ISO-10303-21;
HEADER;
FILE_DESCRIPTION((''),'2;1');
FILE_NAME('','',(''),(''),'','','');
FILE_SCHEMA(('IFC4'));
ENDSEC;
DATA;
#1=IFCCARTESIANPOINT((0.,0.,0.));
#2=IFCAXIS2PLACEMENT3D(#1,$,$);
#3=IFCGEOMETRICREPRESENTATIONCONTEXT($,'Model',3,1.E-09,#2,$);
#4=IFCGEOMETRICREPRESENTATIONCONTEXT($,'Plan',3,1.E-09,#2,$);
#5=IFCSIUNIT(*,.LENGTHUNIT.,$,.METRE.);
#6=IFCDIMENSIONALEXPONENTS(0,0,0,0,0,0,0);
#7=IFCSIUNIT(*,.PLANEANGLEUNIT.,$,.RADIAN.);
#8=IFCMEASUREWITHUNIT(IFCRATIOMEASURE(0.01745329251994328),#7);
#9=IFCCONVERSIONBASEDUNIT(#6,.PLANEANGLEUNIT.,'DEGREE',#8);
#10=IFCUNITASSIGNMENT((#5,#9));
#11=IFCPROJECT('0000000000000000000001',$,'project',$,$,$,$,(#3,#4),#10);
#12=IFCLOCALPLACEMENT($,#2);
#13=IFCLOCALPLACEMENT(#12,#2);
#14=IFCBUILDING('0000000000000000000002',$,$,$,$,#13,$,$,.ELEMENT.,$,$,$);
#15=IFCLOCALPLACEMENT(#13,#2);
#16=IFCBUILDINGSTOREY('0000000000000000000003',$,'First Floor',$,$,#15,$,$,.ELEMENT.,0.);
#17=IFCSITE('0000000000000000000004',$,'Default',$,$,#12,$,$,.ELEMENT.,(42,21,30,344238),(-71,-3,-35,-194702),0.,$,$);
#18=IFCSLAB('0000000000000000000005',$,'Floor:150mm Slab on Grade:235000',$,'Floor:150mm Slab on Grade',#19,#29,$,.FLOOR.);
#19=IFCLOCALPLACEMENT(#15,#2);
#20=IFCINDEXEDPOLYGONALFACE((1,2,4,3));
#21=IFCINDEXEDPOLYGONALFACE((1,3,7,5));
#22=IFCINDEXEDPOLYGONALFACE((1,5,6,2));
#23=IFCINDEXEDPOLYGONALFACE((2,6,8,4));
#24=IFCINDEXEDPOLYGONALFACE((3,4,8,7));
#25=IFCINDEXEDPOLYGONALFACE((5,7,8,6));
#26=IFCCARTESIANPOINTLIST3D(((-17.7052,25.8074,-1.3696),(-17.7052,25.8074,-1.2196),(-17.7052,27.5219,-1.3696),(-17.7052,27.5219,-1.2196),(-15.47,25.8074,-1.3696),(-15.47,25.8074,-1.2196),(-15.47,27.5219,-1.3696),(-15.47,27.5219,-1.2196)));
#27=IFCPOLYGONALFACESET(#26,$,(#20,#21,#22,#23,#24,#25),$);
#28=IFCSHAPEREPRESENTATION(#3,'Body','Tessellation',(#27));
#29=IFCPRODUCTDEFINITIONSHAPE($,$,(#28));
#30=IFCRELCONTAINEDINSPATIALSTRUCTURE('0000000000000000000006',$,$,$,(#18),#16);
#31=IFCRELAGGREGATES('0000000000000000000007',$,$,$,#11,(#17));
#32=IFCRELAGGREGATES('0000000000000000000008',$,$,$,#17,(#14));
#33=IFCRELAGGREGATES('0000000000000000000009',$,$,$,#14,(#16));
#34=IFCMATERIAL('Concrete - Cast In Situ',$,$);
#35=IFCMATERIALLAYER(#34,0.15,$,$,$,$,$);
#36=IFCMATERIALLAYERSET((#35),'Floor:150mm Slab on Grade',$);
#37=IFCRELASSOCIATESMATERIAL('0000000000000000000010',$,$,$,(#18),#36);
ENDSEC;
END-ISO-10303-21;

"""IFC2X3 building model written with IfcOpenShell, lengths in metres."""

from ifc_helpers import new_model, entity, si_unit, converted_unit, frame, origin, origin_2d_with_axis, place, context, project, spatial, rectangle, extrude, material, layer, layer_set, layer_usage, element, save


model = new_model("IFC2X3")

# Units and contexts
model_context = context("Model", 3, precision=1e-09, world=origin())
plan_context = context("Plan", 3, precision=1e-09, world=origin())
ifc_project = project(units=[si_unit("LENGTHUNIT", "METRE"), converted_unit("PLANEANGLEUNIT", "DEGREE", entity("IfcRatioMeasure", 0.01745329251994328), si_unit("PLANEANGLEUNIT", "RADIAN"), dimensions=[0, 0, 0, 0, 0, 0, 0])], contexts=[model_context, plan_context])

# Site, building, storey
site_placement = place(None, origin())
site = spatial("IfcSite", under=ifc_project, at=site_placement, Name="Default", CompositionType="ELEMENT", RefLatitude=(42, 21, 30, 344238), RefLongitude=(-71, -3, -35, -194702), RefElevation=0.0)
building_placement = place(site_placement, origin())
building = spatial("IfcBuilding", under=site, at=building_placement, CompositionType="ELEMENT")
storey_placement = place(building_placement, origin())
storey = spatial("IfcBuildingStorey", under=building, at=storey_placement, Name="First Floor", CompositionType="ELEMENT", Elevation=0.0)

# Slab
ifc_material_1 = material(Name="Concrete - Cast In Situ")
ifc_layer = layer(ifc_material_1, 0.15)
ifc_layer_set = layer_set([ifc_layer], Name="Floor:150mm Slab on Grade")
ifc_layer_usage = layer_usage(ifc_layer_set, "AXIS3", "POSITIVE", 0.0)
slab_placement = place(storey_placement, frame((-17.7052, 25.8074, -1.3696)))
element("IfcSlab", 1, at=slab_placement, inside=storey, material=ifc_layer_usage, Name="Floor:150mm Slab on Grade:235000", ObjectType="Floor:150mm Slab on Grade", PredefinedType="FLOOR", context=model_context, shape_type="SweptSolid", body=[
    extrude(rectangle(XDim=2.2352, YDim=1.7145, at=origin_2d_with_axis()), frame((1.1176, 0.8572, 0.15), z_axis=(0.0, 0.0, -1.0), x_axis=(-1.0, 0.0, 0.0)), (0.0, 0.0, 1.0), 0.15),
])

save(model, "model.ifc")
